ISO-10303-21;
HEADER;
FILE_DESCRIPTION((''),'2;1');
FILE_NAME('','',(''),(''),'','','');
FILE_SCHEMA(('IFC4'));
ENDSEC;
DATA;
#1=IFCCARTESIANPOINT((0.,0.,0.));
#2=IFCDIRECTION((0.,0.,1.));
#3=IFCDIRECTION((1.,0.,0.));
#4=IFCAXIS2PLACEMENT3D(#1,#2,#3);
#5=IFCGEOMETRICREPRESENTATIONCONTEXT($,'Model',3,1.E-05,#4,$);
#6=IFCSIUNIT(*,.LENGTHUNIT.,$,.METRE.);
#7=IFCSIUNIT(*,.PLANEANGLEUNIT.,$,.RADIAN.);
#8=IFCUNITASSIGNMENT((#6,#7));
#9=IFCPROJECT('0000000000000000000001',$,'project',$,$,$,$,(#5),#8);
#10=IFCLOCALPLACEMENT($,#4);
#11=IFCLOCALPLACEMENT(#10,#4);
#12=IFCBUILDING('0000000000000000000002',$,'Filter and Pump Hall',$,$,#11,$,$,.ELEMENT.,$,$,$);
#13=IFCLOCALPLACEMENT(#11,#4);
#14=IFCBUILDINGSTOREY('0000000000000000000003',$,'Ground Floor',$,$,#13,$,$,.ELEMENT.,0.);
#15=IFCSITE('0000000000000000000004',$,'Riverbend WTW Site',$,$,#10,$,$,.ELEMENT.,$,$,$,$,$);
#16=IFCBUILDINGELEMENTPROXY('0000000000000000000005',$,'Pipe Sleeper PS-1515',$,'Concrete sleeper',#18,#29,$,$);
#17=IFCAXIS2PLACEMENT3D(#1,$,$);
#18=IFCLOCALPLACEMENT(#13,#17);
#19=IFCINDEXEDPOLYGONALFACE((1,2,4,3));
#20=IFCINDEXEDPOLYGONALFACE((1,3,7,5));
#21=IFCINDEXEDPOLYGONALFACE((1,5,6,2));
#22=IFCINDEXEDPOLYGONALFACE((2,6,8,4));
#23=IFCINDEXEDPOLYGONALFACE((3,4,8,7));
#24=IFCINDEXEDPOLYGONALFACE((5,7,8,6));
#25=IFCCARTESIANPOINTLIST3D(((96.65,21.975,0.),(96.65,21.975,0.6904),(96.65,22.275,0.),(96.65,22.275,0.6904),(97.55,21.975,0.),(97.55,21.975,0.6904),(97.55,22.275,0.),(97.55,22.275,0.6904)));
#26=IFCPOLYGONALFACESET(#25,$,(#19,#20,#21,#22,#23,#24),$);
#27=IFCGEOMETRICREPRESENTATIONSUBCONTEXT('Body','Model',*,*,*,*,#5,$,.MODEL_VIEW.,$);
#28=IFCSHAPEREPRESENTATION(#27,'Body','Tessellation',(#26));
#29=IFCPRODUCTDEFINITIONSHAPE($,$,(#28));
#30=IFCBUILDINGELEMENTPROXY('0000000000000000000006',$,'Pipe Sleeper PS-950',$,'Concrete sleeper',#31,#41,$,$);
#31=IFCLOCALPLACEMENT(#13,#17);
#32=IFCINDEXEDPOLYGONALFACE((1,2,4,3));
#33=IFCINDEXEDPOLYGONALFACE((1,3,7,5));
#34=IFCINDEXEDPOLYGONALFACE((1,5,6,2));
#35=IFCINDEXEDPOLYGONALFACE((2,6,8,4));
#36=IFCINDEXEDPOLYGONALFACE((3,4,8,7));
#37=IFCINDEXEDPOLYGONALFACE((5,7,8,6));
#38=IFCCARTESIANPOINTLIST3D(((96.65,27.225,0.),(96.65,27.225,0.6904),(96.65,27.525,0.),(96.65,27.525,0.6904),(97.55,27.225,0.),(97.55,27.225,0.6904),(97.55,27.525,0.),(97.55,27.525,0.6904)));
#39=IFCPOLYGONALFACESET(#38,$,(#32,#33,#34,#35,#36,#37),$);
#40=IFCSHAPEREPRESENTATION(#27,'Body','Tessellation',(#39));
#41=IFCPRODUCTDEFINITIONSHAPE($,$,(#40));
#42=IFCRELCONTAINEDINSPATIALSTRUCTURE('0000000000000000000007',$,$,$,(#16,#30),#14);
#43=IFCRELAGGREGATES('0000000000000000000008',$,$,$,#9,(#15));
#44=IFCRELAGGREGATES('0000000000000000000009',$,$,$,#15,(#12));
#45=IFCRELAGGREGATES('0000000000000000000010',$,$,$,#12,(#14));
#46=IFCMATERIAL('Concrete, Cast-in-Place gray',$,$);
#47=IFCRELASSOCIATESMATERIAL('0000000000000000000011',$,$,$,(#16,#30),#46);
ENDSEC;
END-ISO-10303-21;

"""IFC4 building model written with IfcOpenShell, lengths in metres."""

from ifc_helpers import new_model, si_unit, frame, origin_with_axes, origin_2d, place, context, subcontext, project, spatial, rectangle, extrude, material, element, save


model = new_model("IFC4")

# Units and contexts
model_context = context("Model", 3, precision=1e-05, world=origin_with_axes())
body_context = subcontext(model_context, "Body", "Model", "MODEL_VIEW")
ifc_project = project(units=[si_unit("LENGTHUNIT", "METRE"), si_unit("PLANEANGLEUNIT", "RADIAN")], contexts=[model_context])

# Site, building, storey
site_placement = place(None, origin_with_axes())
site = spatial("IfcSite", under=ifc_project, at=site_placement, Name="Riverbend WTW Site", CompositionType="ELEMENT")
building_placement = place(site_placement, origin_with_axes())
building = spatial("IfcBuilding", under=site, at=building_placement, Name="Filter and Pump Hall", CompositionType="ELEMENT")
storey_placement = place(building_placement, origin_with_axes())
storey = spatial("IfcBuildingStorey", under=building, at=storey_placement, Name="Ground Floor", CompositionType="ELEMENT", Elevation=0.0)

# Shared definitions
ifc_material_1 = material(Name="Concrete, Cast-in-Place gray")

# Building element proxies
for number, where, z_axis, x_axis, name in (
    (1, (97.1, 22.125, 0.3452), (0.0, 0.0, 1.0), (1.0, 0.0, 0.0), "Pipe Sleeper PS-1515"),
    (2, (97.1, 27.375, 0.3452), (0.0, 0.0, 1.0), (1.0, 0.0, 0.0), "Pipe Sleeper PS-950"),
):
    element("IfcBuildingElementProxy", number, at=place(None, frame(where, z_axis=z_axis, x_axis=x_axis)), inside=storey, material=ifc_material_1, Name=name, ObjectType="Concrete sleeper", context=body_context, shape_type="SweptSolid", body=[
        extrude(rectangle(XDim=0.9, YDim=0.3, at=origin_2d()), frame((0.0, 0.0, -0.3452), z_axis=(0.0, 0.0, 1.0), x_axis=(1.0, 0.0, 0.0)), (0.0, 0.0, 1.0), 0.6905),
    ])

save(model, "model.ifc")
